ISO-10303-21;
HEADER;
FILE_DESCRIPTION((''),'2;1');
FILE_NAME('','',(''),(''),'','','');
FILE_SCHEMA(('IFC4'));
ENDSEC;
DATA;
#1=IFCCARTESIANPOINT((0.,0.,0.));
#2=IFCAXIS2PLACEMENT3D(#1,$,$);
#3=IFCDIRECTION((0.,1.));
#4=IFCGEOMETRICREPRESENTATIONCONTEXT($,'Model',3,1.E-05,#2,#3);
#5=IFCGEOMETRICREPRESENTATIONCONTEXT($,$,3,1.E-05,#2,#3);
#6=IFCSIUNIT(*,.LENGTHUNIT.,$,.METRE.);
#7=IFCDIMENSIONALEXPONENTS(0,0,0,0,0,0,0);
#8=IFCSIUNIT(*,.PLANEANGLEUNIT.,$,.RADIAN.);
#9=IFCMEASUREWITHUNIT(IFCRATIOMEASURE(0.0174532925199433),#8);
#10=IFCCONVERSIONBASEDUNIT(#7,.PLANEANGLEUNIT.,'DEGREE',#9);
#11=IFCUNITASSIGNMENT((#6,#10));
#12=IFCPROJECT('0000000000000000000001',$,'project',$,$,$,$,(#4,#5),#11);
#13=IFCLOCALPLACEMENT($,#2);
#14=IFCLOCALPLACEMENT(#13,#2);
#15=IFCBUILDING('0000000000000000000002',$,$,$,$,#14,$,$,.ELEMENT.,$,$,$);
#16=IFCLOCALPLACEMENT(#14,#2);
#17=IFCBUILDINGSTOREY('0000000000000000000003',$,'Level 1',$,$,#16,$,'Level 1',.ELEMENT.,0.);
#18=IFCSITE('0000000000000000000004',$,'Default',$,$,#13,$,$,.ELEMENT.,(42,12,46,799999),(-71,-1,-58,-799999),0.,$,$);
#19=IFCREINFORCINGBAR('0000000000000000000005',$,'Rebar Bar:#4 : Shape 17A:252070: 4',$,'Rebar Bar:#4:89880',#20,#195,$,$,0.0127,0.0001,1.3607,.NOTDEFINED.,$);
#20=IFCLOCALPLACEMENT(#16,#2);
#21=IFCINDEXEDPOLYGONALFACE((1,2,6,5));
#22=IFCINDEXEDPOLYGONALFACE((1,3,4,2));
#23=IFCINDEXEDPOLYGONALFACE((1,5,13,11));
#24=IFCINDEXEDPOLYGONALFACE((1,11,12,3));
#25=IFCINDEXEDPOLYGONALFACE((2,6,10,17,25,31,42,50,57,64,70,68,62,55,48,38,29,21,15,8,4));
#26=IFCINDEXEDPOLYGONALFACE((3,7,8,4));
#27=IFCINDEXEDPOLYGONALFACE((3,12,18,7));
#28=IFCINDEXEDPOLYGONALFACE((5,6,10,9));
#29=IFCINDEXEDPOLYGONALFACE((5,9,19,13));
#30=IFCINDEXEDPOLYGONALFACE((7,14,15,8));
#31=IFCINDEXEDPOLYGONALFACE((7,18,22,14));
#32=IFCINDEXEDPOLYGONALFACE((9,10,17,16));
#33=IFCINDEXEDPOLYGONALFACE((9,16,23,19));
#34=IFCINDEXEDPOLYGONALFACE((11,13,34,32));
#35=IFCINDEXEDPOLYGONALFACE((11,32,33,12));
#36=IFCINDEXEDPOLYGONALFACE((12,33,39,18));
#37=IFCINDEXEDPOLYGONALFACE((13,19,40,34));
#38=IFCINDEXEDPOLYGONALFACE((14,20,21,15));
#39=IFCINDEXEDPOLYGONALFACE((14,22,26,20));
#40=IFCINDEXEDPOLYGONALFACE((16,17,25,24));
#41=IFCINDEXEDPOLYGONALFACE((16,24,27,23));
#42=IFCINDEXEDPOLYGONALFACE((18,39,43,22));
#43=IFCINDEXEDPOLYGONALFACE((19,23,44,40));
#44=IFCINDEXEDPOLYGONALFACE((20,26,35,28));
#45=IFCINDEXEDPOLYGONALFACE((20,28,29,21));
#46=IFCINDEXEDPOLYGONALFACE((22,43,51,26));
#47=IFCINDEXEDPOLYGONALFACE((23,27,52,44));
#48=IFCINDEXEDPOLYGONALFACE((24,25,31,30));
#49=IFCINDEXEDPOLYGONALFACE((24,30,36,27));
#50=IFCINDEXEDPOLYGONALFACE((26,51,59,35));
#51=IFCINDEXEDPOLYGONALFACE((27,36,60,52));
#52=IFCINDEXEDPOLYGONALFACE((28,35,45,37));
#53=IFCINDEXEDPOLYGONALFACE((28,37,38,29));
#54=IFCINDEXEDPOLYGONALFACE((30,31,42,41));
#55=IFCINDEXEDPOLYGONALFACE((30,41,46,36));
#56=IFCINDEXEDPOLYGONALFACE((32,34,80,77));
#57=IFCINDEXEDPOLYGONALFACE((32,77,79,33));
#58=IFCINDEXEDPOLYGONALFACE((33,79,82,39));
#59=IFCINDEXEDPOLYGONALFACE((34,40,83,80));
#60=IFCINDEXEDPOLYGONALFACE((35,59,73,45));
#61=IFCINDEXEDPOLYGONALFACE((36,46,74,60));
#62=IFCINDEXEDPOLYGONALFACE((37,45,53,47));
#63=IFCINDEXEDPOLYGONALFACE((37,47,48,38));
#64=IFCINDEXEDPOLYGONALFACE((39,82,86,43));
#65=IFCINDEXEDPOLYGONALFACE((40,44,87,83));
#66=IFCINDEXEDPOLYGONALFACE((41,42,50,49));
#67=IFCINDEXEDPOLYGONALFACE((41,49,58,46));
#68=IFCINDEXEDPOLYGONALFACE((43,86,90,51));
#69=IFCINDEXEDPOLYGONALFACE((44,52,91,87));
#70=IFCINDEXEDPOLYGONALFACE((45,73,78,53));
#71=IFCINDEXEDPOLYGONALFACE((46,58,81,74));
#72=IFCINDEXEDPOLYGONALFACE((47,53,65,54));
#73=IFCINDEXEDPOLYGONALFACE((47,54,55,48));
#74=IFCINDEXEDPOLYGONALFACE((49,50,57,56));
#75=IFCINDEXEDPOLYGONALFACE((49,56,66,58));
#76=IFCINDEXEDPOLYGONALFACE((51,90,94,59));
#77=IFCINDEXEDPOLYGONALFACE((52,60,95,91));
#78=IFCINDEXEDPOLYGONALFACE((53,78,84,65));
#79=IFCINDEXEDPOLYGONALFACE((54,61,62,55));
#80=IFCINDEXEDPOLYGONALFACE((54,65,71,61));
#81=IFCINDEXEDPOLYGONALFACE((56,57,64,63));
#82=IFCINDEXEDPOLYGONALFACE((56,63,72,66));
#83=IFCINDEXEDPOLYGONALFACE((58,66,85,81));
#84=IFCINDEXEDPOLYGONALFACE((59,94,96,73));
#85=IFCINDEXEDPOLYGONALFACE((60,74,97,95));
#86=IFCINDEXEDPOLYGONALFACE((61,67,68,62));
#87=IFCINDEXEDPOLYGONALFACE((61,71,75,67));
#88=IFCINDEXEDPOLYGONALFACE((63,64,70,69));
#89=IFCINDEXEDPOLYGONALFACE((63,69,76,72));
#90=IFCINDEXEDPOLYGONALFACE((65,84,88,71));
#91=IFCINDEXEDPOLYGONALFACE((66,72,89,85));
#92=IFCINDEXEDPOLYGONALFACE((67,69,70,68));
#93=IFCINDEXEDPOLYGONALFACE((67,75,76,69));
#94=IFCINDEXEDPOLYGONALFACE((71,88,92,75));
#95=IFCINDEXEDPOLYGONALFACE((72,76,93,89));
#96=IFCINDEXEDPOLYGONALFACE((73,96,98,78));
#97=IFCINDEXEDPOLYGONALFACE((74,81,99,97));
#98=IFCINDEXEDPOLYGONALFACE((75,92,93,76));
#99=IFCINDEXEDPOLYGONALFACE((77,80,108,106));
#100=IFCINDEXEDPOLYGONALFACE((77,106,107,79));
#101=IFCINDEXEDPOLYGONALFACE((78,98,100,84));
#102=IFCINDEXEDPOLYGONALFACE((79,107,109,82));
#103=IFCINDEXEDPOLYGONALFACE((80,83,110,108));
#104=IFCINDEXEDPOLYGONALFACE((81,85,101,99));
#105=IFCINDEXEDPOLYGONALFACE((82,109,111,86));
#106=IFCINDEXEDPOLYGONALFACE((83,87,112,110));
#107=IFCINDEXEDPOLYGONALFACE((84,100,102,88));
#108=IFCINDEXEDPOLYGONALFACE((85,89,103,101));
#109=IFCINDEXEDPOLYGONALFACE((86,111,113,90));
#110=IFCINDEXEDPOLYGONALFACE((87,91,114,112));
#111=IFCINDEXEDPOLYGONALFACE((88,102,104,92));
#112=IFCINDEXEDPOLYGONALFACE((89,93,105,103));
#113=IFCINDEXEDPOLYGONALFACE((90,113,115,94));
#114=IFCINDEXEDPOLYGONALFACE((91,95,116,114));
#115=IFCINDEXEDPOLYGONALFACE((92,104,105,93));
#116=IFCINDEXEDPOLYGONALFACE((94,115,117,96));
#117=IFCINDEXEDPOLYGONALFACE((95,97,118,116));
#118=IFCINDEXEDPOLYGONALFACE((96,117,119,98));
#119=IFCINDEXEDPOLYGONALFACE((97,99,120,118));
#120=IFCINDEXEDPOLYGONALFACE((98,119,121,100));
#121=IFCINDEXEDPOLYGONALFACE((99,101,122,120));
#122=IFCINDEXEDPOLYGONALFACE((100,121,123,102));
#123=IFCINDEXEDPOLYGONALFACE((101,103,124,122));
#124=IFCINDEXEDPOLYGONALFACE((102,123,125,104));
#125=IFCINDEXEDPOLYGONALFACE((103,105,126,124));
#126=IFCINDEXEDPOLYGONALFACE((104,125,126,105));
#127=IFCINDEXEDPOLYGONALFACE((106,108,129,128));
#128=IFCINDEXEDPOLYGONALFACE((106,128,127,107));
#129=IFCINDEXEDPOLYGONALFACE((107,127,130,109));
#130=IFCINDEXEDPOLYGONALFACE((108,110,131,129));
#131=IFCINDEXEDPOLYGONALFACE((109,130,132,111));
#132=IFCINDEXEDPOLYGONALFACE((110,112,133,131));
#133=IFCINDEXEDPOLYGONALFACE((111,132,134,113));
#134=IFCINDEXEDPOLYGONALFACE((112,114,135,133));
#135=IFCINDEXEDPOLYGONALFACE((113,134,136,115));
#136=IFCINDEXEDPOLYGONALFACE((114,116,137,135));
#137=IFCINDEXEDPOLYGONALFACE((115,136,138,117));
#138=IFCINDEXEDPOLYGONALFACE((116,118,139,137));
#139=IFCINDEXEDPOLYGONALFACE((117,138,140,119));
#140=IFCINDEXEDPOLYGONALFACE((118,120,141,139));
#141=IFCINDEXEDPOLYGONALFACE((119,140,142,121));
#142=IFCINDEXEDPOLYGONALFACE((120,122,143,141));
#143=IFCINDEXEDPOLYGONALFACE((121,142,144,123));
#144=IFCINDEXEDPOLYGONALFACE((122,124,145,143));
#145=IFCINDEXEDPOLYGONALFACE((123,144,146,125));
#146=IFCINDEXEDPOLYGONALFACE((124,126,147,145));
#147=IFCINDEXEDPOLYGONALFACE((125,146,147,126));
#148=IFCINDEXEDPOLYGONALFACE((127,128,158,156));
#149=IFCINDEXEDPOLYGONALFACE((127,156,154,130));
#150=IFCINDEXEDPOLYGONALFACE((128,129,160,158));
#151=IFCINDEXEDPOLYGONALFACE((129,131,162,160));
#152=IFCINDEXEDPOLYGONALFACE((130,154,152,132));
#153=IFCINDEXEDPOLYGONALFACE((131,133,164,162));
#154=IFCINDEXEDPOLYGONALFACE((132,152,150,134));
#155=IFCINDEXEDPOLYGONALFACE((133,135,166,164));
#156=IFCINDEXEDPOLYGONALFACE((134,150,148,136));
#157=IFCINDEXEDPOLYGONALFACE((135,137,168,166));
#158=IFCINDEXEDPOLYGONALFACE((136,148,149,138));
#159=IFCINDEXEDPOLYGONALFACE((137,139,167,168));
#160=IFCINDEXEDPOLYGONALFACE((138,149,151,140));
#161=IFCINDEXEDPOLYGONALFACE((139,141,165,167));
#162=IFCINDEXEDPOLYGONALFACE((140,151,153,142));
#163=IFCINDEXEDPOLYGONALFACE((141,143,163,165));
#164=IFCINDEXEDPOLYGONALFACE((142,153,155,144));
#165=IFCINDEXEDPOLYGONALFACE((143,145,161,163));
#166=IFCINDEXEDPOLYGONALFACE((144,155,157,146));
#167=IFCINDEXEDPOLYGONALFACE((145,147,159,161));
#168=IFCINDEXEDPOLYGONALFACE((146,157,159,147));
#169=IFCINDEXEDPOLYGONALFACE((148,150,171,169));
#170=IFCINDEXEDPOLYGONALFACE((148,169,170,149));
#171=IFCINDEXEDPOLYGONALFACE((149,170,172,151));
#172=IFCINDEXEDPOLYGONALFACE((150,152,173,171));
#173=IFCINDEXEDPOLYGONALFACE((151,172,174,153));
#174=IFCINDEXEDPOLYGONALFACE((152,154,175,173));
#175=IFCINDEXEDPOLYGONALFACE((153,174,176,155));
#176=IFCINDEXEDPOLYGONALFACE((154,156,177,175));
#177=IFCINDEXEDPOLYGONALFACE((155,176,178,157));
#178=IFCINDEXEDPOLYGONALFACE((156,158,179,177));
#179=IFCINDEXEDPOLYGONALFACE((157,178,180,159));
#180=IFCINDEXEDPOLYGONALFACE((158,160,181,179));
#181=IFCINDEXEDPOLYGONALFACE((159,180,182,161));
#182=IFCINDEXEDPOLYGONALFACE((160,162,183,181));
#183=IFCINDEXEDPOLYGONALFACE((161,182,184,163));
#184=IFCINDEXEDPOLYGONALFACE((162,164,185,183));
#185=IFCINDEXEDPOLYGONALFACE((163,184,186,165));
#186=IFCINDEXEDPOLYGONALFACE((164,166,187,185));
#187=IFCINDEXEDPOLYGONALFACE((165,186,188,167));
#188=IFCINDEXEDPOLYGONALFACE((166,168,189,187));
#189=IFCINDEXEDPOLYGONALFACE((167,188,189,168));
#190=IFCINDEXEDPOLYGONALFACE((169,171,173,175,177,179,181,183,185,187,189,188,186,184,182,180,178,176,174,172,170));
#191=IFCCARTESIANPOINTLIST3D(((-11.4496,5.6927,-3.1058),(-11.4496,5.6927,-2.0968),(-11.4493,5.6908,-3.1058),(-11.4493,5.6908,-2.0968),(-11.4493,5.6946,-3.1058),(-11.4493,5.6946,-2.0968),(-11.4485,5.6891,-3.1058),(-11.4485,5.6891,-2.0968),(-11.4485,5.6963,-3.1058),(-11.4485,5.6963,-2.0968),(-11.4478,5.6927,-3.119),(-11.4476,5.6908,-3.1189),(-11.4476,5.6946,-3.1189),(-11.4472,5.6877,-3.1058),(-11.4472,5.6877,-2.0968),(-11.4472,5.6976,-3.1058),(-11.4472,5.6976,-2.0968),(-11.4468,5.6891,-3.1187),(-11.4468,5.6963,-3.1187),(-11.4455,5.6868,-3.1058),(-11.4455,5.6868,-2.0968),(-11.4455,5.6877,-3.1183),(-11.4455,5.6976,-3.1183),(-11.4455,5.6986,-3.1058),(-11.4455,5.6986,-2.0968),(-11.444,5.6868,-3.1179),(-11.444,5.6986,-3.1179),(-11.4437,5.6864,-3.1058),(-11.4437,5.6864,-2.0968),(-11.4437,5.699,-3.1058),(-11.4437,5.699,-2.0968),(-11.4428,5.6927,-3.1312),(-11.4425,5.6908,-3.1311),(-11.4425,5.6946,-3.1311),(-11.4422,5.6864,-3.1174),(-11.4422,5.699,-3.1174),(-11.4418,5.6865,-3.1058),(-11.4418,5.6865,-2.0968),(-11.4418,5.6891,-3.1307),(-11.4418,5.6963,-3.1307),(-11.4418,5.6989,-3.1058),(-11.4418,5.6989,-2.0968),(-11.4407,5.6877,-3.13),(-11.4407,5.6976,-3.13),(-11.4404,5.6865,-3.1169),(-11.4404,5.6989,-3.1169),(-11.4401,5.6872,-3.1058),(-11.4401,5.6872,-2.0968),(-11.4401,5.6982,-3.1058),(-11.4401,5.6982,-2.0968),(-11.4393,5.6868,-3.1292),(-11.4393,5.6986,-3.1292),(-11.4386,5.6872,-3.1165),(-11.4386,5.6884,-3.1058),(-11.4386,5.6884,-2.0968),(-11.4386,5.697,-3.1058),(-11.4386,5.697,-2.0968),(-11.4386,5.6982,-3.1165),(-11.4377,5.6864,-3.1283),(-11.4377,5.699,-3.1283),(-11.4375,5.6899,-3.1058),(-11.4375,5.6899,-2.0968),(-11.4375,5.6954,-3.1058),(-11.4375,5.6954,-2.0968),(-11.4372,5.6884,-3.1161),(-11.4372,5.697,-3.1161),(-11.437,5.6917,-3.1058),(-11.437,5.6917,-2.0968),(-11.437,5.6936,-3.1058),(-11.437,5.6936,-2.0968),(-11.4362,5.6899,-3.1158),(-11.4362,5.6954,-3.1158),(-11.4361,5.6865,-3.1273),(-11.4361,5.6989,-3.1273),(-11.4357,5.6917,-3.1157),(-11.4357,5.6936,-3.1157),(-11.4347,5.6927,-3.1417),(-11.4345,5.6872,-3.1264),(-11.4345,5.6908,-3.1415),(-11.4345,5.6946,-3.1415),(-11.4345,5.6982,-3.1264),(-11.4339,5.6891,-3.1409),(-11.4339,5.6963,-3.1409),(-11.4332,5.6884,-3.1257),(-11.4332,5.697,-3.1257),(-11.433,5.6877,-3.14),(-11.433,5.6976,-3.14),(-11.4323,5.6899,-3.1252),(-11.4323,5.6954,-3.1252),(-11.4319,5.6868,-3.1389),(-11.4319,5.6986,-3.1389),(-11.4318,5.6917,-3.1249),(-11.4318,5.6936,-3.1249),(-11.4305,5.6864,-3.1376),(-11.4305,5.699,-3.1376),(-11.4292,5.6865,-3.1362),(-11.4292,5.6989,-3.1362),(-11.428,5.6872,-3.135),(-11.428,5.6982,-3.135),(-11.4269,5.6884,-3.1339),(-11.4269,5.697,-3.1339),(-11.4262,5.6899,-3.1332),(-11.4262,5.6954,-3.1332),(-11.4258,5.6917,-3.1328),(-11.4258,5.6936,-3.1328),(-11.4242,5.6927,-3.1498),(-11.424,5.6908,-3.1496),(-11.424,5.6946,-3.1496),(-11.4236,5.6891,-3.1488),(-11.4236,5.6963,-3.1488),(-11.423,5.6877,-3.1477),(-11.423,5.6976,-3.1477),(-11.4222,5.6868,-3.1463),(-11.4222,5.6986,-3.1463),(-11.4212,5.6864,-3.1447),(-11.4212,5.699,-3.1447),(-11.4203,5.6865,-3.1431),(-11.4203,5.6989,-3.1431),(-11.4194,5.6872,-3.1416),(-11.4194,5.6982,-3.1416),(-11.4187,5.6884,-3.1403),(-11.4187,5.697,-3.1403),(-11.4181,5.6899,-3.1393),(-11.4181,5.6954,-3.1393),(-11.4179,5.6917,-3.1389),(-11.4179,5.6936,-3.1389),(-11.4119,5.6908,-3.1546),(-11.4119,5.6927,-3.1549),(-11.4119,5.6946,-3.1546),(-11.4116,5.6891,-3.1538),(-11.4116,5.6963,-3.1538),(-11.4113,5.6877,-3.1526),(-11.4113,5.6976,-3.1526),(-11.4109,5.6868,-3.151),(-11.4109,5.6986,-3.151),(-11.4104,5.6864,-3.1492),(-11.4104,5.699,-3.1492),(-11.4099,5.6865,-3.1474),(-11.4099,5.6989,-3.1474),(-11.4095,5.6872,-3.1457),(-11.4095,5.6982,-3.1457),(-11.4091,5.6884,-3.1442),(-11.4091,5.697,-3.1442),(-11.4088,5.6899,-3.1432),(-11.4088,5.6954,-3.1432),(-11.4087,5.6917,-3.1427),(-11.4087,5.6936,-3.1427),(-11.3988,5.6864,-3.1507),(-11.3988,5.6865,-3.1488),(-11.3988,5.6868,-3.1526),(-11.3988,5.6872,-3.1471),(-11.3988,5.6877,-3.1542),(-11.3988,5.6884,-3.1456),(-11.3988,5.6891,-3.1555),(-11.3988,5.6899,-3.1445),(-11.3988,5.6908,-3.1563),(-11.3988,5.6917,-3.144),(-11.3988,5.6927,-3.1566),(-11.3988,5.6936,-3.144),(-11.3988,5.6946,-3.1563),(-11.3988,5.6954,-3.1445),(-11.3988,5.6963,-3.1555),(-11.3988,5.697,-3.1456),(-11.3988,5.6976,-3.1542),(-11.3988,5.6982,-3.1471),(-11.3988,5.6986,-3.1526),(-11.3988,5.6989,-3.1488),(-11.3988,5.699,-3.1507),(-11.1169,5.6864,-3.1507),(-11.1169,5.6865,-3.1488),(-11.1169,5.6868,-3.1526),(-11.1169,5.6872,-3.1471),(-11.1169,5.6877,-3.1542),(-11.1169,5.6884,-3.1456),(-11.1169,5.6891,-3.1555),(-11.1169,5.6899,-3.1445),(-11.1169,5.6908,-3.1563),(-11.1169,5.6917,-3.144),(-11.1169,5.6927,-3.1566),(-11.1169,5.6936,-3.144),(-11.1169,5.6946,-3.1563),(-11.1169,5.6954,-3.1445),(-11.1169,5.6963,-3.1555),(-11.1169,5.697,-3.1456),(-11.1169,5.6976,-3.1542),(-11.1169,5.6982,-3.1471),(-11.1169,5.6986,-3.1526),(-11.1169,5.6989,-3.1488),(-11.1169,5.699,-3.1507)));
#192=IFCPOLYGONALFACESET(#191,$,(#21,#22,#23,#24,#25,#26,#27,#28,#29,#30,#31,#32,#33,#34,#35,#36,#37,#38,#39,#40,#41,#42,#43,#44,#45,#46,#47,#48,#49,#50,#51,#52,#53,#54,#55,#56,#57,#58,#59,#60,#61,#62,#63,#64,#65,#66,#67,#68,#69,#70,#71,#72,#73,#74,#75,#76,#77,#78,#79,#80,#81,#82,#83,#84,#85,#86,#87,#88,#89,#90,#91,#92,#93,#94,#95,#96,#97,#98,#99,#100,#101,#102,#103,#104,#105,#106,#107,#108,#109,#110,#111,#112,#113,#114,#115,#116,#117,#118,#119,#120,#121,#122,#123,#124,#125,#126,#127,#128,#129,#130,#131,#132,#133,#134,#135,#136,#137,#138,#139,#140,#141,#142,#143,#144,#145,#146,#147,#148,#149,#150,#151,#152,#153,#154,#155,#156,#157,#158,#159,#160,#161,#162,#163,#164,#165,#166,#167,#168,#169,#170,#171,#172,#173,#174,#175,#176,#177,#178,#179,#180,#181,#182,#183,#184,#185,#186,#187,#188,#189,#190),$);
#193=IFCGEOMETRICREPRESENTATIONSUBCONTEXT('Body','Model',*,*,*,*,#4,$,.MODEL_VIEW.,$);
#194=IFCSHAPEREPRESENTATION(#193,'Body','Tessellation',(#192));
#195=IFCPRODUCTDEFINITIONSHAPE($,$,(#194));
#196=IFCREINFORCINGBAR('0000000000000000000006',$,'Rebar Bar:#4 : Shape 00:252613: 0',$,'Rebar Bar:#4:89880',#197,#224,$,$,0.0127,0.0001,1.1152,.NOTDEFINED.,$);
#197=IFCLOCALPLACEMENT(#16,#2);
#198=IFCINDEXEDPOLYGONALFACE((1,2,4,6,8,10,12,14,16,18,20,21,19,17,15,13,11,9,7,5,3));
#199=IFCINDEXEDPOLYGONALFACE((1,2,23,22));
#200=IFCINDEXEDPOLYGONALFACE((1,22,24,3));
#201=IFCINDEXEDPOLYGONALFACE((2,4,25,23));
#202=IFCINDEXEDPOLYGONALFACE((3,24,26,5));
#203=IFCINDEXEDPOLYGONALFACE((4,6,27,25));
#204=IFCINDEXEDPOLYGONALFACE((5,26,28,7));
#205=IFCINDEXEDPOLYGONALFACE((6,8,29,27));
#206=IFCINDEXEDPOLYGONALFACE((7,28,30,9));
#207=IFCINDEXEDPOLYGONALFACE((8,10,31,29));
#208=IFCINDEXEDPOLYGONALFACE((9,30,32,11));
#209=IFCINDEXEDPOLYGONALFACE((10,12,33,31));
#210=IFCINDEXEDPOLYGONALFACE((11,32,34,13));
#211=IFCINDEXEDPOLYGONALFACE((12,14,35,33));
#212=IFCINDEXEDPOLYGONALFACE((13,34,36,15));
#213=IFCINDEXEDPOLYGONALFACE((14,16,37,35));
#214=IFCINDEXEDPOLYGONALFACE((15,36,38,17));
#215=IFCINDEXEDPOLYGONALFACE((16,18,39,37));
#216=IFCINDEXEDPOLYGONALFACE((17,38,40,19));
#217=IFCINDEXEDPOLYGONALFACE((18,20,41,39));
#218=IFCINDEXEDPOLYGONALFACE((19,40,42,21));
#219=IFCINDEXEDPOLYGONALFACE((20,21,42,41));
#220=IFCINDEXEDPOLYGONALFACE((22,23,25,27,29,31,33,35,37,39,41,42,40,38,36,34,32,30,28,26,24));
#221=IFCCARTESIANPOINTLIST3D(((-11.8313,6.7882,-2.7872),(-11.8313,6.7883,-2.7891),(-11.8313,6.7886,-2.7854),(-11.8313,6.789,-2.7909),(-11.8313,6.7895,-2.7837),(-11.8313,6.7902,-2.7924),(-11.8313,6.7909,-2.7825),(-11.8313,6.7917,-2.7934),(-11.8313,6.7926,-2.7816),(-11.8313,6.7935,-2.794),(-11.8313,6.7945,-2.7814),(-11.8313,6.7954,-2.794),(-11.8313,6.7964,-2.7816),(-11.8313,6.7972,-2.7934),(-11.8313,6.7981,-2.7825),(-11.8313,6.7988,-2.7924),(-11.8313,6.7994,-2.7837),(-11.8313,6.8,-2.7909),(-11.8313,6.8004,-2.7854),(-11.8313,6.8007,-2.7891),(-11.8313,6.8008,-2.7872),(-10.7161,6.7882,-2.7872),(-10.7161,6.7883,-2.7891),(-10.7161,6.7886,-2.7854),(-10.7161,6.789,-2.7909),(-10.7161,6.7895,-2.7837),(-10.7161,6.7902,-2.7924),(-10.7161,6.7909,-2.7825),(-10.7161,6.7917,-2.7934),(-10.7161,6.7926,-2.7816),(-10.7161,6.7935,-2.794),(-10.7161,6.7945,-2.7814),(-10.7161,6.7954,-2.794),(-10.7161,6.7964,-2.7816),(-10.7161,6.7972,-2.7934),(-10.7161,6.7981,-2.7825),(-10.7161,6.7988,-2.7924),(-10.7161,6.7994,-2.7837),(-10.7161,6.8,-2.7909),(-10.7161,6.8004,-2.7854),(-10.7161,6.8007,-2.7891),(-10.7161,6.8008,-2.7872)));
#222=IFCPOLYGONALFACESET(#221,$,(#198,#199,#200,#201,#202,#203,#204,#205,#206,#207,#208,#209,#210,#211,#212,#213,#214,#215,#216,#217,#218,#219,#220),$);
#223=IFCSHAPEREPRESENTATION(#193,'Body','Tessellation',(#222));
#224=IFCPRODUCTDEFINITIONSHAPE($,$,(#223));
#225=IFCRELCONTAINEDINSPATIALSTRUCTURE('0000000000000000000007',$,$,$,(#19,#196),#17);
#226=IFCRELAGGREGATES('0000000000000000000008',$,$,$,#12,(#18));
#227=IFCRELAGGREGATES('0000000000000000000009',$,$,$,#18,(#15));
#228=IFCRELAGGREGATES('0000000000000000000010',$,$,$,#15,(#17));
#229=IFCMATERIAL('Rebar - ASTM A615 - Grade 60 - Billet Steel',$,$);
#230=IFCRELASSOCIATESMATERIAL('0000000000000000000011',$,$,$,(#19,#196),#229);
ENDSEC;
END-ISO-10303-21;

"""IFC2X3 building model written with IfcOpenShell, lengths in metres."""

from ifc_helpers import new_model, entity, si_unit, converted_unit, direction, origin, place, context, subcontext, project, spatial, material, element, save


model = new_model("IFC2X3")

# Units and contexts
model_context = context("Model", 3, precision=1e-05, world=origin(), true_north=direction((0.0, 1.0)))
context_of_model = context(None, 3, precision=1e-05, world=origin(), true_north=direction((0.0, 1.0)))
body_context = subcontext(model_context, "Body", "Model", "MODEL_VIEW")
ifc_project = project(units=[si_unit("LENGTHUNIT", "METRE"), converted_unit("PLANEANGLEUNIT", "DEGREE", entity("IfcRatioMeasure", 0.0174532925199433), si_unit("PLANEANGLEUNIT", "RADIAN"), dimensions=[0, 0, 0, 0, 0, 0, 0])], contexts=[model_context, context_of_model])

# Site, building, storey
site_placement = place(None, origin())
site = spatial("IfcSite", under=ifc_project, at=site_placement, Name="Default", CompositionType="ELEMENT", RefLatitude=(42, 12, 46, 799999), RefLongitude=(-71, -1, -58, -799999), RefElevation=0.0)
building_placement = place(site_placement, origin())
building = spatial("IfcBuilding", under=site, at=building_placement, CompositionType="ELEMENT")
storey_placement = place(building_placement, origin())
storey = spatial("IfcBuildingStorey", under=building, at=storey_placement, Name="Level 1", LongName="Level 1", CompositionType="ELEMENT", Elevation=0.0)

# Reinforcing bars
ifc_material_1 = material(Name="Rebar - ASTM A615 - Grade 60 - Billet Steel")
reinforcing_bar_1_placement = place(storey_placement, origin())
element("IfcReinforcingBar", 1, at=reinforcing_bar_1_placement, inside=storey, material=ifc_material_1, Name="Rebar Bar:#4 : Shape 17A:252070: 4", ObjectType="Rebar Bar:#4:89880", BarLength=1.3607, BarRole="NOTDEFINED", CrossSectionArea=0.0001, NominalDiameter=0.0127, context=body_context, shape_type="AdvancedSweptSolid", body=[
    entity("IfcSweptDiskSolid", entity("IfcCompositeCurve", [entity("IfcCompositeCurveSegment", "CONTINUOUS", True, entity("IfcPolyline", [entity("IfcCartesianPoint", [-11.4432, 5.6927, -2.0968]), entity("IfcCartesianPoint", [-11.4432, 5.6927, -3.1058])])), entity("IfcCompositeCurveSegment", "CONTINUOUS", True, entity("IfcTrimmedCurve", entity("IfcCircle", entity("IfcAxis2Placement3D", entity("IfcCartesianPoint", [-11.3988, 5.6927, -3.1058]), entity("IfcDirection", [0.0, -1.0, 0.0]), entity("IfcDirection", [0.0, 0.0, -1.0])), 0.0445), [entity("IfcParameterValue", 270.0)], [entity("IfcParameterValue", 360.0)], True, "PARAMETER")), entity("IfcCompositeCurveSegment", "CONTINUOUS", True, entity("IfcPolyline", [entity("IfcCartesianPoint", [-11.3988, 5.6927, -3.1503]), entity("IfcCartesianPoint", [-11.1169, 5.6927, -3.1503])]))], False), 0.0063, None, 0.0, 92.0),
])
reinforcing_bar_2_placement = place(storey_placement, origin())
element("IfcReinforcingBar", 2, at=reinforcing_bar_2_placement, inside=storey, material=ifc_material_1, Name="Rebar Bar:#4 : Shape 00:252613: 0", ObjectType="Rebar Bar:#4:89880", BarLength=1.1152, BarRole="NOTDEFINED", CrossSectionArea=0.0001, NominalDiameter=0.0127, context=body_context, shape_type="AdvancedSweptSolid", body=[
    entity("IfcSweptDiskSolid", entity("IfcCompositeCurve", [entity("IfcCompositeCurveSegment", "CONTINUOUS", True, entity("IfcPolyline", [entity("IfcCartesianPoint", [-11.8313, 6.7945, -2.7877]), entity("IfcCartesianPoint", [-10.7161, 6.7945, -2.7877])]))], False), 0.0063, None, 0.0, 1.0),
])

save(model, "model.ifc")
